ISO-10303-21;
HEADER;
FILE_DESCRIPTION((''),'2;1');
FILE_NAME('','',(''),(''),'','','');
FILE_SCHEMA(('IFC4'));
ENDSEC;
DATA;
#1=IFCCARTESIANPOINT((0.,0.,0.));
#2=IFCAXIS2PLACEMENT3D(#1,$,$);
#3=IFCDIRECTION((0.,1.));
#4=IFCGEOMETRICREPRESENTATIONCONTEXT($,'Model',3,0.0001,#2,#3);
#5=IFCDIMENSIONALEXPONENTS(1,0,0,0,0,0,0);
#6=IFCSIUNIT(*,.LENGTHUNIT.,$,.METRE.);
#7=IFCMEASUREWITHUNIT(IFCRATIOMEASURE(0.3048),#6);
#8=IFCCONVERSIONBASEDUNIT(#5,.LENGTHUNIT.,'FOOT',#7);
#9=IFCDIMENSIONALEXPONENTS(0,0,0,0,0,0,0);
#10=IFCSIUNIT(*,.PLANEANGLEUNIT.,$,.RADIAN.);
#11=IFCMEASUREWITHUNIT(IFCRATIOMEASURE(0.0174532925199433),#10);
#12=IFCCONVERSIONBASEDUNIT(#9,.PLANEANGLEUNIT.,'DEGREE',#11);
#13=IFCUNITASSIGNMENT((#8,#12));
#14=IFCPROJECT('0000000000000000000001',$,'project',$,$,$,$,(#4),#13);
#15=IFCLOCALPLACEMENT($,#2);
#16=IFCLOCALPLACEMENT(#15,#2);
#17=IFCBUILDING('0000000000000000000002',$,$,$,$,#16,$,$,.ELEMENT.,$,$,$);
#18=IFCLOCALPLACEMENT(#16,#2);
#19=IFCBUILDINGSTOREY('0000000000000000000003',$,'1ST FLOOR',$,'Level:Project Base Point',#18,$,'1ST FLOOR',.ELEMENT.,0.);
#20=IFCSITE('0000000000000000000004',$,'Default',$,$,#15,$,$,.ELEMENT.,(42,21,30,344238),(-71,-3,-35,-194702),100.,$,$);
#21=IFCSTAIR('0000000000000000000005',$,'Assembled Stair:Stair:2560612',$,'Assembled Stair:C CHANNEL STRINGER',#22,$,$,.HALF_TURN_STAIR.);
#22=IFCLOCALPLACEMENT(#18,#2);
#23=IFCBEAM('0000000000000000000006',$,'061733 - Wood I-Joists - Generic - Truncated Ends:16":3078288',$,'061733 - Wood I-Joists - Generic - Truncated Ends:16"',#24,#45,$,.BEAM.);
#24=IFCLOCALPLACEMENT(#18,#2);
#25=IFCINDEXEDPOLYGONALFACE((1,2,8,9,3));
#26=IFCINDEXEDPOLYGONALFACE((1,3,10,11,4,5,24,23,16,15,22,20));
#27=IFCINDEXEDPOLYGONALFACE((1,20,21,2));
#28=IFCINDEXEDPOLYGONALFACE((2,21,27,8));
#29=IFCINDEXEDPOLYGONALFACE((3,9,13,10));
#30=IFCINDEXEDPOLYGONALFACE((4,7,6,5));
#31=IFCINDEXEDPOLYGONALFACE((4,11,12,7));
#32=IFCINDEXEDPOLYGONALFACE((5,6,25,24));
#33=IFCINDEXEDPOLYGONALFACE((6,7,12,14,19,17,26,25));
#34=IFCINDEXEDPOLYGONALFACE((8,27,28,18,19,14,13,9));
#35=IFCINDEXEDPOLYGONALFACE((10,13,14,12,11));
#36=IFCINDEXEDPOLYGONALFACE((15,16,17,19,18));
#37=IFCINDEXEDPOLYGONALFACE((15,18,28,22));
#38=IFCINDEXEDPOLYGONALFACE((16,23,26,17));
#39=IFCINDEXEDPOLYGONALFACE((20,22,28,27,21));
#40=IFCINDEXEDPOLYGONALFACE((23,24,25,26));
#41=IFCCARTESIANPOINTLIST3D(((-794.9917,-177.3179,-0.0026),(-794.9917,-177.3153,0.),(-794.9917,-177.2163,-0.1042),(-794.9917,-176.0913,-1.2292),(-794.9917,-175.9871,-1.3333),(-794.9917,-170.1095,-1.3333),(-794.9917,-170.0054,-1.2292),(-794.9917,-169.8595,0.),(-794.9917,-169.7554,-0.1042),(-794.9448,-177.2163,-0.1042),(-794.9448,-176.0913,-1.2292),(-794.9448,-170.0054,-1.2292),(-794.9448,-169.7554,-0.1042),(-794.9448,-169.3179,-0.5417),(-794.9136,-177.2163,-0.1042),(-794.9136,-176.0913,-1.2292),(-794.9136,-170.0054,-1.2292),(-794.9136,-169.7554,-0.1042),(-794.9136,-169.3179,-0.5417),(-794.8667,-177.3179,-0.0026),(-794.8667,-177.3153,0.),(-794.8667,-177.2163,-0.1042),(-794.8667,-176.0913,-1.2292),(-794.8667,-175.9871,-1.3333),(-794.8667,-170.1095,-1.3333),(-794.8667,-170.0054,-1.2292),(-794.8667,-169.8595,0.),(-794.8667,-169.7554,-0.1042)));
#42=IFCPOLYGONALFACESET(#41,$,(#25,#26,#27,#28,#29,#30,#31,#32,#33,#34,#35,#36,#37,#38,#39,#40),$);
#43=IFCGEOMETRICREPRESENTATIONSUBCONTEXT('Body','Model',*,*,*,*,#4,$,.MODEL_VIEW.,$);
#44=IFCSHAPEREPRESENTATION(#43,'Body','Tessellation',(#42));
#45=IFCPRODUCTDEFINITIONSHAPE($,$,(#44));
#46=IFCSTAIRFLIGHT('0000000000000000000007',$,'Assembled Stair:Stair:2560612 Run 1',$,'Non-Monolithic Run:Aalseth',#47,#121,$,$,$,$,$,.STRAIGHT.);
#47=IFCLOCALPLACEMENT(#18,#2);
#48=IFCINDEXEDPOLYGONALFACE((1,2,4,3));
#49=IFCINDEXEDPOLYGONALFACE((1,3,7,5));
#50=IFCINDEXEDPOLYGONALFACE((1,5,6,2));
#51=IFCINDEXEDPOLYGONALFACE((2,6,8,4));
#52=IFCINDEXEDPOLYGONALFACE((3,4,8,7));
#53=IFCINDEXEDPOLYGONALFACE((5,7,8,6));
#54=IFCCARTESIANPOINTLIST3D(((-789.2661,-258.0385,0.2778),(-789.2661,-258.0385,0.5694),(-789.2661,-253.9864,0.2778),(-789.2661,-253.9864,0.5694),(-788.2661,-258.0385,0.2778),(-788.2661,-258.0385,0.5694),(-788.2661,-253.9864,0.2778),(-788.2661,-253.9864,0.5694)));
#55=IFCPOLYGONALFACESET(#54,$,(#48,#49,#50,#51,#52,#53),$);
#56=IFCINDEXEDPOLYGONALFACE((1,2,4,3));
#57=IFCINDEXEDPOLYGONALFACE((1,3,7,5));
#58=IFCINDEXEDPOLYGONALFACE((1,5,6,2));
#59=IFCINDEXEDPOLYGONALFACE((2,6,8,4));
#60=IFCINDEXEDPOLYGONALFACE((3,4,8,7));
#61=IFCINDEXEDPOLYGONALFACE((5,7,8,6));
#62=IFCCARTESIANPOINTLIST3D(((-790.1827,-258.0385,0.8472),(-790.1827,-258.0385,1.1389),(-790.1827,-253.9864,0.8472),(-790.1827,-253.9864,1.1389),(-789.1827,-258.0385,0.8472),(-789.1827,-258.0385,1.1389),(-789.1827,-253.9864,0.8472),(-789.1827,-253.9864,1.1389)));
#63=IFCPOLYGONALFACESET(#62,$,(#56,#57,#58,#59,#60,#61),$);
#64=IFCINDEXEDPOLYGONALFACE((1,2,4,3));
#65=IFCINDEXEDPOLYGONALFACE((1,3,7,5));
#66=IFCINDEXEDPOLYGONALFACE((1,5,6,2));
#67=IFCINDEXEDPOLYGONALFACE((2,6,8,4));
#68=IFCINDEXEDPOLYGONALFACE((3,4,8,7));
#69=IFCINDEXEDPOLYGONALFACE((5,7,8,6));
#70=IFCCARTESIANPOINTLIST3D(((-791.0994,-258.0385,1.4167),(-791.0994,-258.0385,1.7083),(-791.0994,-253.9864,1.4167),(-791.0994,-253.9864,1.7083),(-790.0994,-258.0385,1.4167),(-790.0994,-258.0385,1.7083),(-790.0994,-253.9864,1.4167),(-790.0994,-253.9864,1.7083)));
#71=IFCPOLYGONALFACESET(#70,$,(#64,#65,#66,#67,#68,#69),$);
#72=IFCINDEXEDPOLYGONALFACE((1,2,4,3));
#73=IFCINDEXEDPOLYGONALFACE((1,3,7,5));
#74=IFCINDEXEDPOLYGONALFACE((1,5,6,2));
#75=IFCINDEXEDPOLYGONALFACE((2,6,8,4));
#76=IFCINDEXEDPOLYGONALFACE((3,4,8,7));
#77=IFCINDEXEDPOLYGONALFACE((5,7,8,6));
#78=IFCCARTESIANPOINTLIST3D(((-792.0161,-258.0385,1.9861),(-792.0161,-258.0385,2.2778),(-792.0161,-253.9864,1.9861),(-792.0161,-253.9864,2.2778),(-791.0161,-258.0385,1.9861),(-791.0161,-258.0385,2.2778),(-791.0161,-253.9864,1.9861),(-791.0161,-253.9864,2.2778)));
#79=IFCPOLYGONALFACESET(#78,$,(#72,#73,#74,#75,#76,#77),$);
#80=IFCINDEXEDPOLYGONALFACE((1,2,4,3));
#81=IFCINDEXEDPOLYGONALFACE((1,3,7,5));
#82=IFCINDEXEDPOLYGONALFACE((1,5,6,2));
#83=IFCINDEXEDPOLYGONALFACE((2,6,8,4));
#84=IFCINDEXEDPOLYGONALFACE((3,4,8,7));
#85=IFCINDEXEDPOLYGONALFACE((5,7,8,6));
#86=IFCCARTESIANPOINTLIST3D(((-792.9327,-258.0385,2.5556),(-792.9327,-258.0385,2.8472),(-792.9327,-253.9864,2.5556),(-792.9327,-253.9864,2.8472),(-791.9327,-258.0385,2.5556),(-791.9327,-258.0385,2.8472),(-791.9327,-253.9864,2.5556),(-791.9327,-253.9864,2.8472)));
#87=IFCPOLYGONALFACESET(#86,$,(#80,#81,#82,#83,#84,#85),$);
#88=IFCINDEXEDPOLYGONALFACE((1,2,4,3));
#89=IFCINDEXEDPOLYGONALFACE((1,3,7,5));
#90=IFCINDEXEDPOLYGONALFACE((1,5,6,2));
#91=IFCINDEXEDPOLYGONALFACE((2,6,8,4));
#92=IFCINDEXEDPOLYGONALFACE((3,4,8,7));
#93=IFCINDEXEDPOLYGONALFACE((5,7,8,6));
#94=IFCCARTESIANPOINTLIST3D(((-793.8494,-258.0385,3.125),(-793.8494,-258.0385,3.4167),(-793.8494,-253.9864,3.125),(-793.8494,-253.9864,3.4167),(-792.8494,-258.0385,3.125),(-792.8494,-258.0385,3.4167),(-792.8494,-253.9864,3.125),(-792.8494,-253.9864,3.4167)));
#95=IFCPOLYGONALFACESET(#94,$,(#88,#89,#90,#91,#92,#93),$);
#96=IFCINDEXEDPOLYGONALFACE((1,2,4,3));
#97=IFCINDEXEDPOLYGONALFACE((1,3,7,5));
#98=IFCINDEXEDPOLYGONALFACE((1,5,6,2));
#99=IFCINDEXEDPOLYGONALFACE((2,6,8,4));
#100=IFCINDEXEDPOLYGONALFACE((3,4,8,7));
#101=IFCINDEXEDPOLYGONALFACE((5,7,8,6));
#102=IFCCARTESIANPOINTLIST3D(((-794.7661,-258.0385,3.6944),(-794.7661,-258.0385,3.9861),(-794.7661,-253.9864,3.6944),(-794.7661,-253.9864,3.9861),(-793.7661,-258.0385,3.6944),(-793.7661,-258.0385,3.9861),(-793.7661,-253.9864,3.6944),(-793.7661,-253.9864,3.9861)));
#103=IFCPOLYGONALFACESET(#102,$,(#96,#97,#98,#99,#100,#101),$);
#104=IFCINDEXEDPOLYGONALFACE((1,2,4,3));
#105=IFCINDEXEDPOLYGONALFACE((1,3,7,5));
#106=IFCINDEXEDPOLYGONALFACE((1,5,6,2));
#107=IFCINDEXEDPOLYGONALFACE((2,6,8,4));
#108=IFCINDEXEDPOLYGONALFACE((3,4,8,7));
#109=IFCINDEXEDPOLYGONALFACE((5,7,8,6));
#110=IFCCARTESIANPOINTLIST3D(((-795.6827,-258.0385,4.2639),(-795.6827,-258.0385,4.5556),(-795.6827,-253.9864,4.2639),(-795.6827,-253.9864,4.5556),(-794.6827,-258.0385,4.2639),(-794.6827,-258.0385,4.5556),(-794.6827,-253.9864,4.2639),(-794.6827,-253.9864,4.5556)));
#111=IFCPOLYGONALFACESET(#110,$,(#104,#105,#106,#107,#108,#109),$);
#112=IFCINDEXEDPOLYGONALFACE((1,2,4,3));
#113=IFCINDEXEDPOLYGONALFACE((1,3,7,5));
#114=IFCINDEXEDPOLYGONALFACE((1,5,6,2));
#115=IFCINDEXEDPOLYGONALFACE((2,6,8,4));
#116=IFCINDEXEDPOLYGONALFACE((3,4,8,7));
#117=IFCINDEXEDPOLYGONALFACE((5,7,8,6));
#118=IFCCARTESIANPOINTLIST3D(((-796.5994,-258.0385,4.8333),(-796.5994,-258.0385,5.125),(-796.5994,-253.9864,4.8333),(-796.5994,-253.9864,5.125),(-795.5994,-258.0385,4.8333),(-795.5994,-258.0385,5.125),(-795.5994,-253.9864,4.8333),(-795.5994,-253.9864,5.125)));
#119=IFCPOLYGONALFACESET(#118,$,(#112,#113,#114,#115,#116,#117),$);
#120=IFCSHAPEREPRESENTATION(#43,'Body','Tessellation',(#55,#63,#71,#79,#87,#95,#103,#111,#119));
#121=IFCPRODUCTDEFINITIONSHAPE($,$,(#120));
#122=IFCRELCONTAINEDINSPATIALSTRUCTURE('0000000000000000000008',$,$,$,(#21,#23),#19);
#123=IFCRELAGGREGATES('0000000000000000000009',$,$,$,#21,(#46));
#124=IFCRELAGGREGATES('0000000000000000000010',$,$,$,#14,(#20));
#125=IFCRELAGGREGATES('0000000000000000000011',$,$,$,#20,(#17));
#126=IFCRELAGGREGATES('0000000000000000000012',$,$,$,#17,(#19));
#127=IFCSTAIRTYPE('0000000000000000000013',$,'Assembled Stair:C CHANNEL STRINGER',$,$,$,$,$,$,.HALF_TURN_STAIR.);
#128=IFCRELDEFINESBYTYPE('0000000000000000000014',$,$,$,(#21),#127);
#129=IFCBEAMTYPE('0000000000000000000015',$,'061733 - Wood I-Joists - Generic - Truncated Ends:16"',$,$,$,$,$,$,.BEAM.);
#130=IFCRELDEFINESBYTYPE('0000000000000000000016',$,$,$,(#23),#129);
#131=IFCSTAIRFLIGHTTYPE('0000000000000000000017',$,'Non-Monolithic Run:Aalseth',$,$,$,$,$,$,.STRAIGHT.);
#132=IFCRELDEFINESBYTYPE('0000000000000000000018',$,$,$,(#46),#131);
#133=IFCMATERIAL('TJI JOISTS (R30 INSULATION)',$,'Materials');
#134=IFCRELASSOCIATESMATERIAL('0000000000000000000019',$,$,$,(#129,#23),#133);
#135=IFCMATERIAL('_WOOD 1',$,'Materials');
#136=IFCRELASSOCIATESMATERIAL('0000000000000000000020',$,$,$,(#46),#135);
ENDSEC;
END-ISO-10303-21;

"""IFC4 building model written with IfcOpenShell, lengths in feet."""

from ifc_helpers import new_model, entity, si_unit, converted_unit, direction, frame, frame_2d, origin, place, context, subcontext, project, spatial, polyline, rectangle, outline, extrude, clip, bounded_halfspace, source, transform, mapped, material, material_profile, profile_set, profile_usage, type_object, type_shapes, element, aggregate, save


model = new_model("IFC4")

# Units and contexts
model_context = context("Model", 3, precision=0.0001, world=origin(), true_north=direction((0.0, 1.0)))
body_context = subcontext(model_context, "Body", "Model", "MODEL_VIEW")
ifc_project = project(units=[converted_unit("LENGTHUNIT", "FOOT", entity("IfcRatioMeasure", 0.3048), si_unit("LENGTHUNIT", "METRE"), dimensions=[1, 0, 0, 0, 0, 0, 0]), converted_unit("PLANEANGLEUNIT", "DEGREE", entity("IfcRatioMeasure", 0.0174532925199433), si_unit("PLANEANGLEUNIT", "RADIAN"), dimensions=[0, 0, 0, 0, 0, 0, 0])], contexts=[model_context])

# Site, building, storey
site_placement = place(None, origin())
site = spatial("IfcSite", under=ifc_project, at=site_placement, Name="Default", CompositionType="ELEMENT", RefLatitude=(42, 21, 30, 344238), RefLongitude=(-71, -3, -35, -194702), RefElevation=100.0)
building_placement = place(site_placement, origin())
building = spatial("IfcBuilding", under=site, at=building_placement, CompositionType="ELEMENT")
storey_placement = place(building_placement, origin())
storey = spatial("IfcBuildingStorey", under=building, at=storey_placement, Name="1ST FLOOR", ObjectType="Level:Project Base Point", LongName="1ST FLOOR", CompositionType="ELEMENT", Elevation=0.0)

# Stair
stair_type_1 = type_object("IfcStairType", Name="Assembled Stair:C CHANNEL STRINGER", PredefinedType="HALF_TURN_STAIR")
stair_1_placement = place(storey_placement, origin())
stair_1 = element("IfcStair", 1, at=stair_1_placement, inside=storey, type_object=stair_type_1, Name="Assembled Stair:Stair:2560612", ObjectType="Assembled Stair:C CHANNEL STRINGER", PredefinedType="HALF_TURN_STAIR")

# Beam
ifc_material_1 = material(Name="TJI JOISTS (R30 INSULATION)", Category="Materials")
ifc_material_profile_1 = material_profile(ifc_material_1, outline(polyline([(-0.0625, -0.5625), (-0.0625, -0.6667), (0.0625, -0.6667), (0.0625, -0.5625), (0.0156, -0.5625), (0.0156, 0.5625), (0.0625, 0.5625), (0.0625, 0.6667), (-0.0625, 0.6667), (-0.0625, 0.5625), (-0.0156, 0.5625), (-0.0156, -0.5625), (-0.0625, -0.5625)])), Name="16\"")
ifc_profile_set_1 = profile_set([ifc_material_profile_1], Name="16\"")
ifc_profile_usage_1 = profile_usage(ifc_profile_set_1, cardinal=8)
beam_type_1 = type_object("IfcBeamType", Name="061733 - Wood I-Joists - Generic - Truncated Ends:16\"", PredefinedType="BEAM", material=ifc_profile_set_1)
shared_shape_1 = source(origin(), body_context, "Body", "Clipping", [
    clip(clip(clip(clip(extrude(outline(polyline([(-0.0625, -0.5625), (-0.0625, -0.6667), (0.0625, -0.6667), (0.0625, -0.5625), (0.0156, -0.5625), (0.0156, 0.5625), (0.0625, 0.5625), (0.0625, 0.6667), (-0.0625, 0.6667), (-0.0625, 0.5625), (-0.0156, 0.5625), (-0.0156, -0.5625), (-0.0625, -0.5625)])), frame((-4.0, -0.0057, 0.0), z_axis=(-1.0, 0.0, 0.0), x_axis=(0.0, 1.0, 0.0)), (0.0, 0.0, -1.0), 8.0), bounded_halfspace(frame((-3.2083, -0.0682, -0.6667), z_axis=(-0.707107, 0.0, -0.707107), x_axis=(0.0, 1.0, 0.0)), False, frame((-4.0, -0.0057, 0.0), z_axis=(-1.0, 0.0, 0.0), x_axis=(0.0, 1.0, 0.0)), polyline([(-0.0156, -0.125), (0.0156, -0.125), (0.0156, 0.5625), (0.0625, 0.5625), (0.0625, 0.6667), (-0.0625, 0.6667), (-0.0625, 0.5625), (-0.0156, 0.5625), (-0.0156, -0.125)]))), bounded_halfspace(frame((-4.0, -0.0682, 0.125), z_axis=(-0.707107, 0.0, 0.707107), x_axis=(0.0, 1.0, 0.0)), False, frame((-4.0, -0.0057, 0.0), z_axis=(-1.0, 0.0, 0.0), x_axis=(0.0, 1.0, 0.0)), polyline([(0.0156, -0.125), (-0.0156, -0.125), (-0.0156, -0.5625), (-0.0625, -0.5625), (-0.0625, -0.6667), (0.0625, -0.6667), (0.0625, -0.5625), (0.0156, -0.5625), (0.0156, -0.125)]))), bounded_halfspace(frame((4.0, -0.0682, 0.6641), z_axis=(0.707107, 0.0, -0.707107), x_axis=(0.0, 1.0, 0.0)), False, frame((-4.0, -0.0057, 0.0), z_axis=(-1.0, 0.0, 0.0), x_axis=(0.0, 1.0, 0.0)), polyline([(0.0625, -0.6641), (-0.0625, -0.6641), (-0.0625, -0.5625), (-0.0156, -0.5625), (-0.0156, 0.5625), (-0.0625, 0.5625), (-0.0625, 0.6667), (0.0625, 0.6667), (0.0625, 0.5625), (0.0156, 0.5625), (0.0156, -0.5625), (0.0625, -0.5625), (0.0625, -0.6641)]))), bounded_halfspace(frame((3.9974, -0.0682, 0.6667), z_axis=(0.707107, 0.0, 0.707107), x_axis=(0.0, 1.0, 0.0)), False, frame((-4.0, -0.0057, 0.0), z_axis=(-1.0, 0.0, 0.0), x_axis=(0.0, 1.0, 0.0)), polyline([(-0.0625, -0.6641), (0.0625, -0.6641), (0.0625, -0.6667), (-0.0625, -0.6667), (-0.0625, -0.6641)]))),
])
type_shapes(beam_type_1, [shared_shape_1])
beam_1_placement = place(storey_placement, frame((-794.9235, -173.3179, -0.6667), z_axis=(0.0, 0.0, 1.0), x_axis=(0.0, -1.0, 0.0)))
element("IfcBeam", 2, at=beam_1_placement, inside=storey, type_object=beam_type_1, material=ifc_profile_usage_1, Name="061733 - Wood I-Joists - Generic - Truncated Ends:16\":3078288", ObjectType="061733 - Wood I-Joists - Generic - Truncated Ends:16\"", PredefinedType="BEAM", context=body_context, shape_type="MappedRepresentation", body=[
    mapped(shared_shape_1, transform((0.0, 0.0, 0.0), scale=1.0)),
])

# Shared definitions
ifc_material_2 = material(Name="_WOOD 1", Category="Materials")

# Stair flight
stair_flight_type_1 = type_object("IfcStairFlightType", Name="Non-Monolithic Run:Aalseth", PredefinedType="STRAIGHT")
stair_flight_1_placement = place(stair_1_placement, frame((-796.5994, -258.0385, 0.0)))
stair_flight_1 = element("IfcStairFlight", 3, at=stair_flight_1_placement, type_object=stair_flight_type_1, material=ifc_material_2, Name="Assembled Stair:Stair:2560612 Run 1", ObjectType="Non-Monolithic Run:Aalseth", PredefinedType="STRAIGHT", context=body_context, shape_type="SweptSolid", body=[
    extrude(rectangle(XDim=1.0, YDim=4.0521, at=frame_2d((0.0, 0.0), x_axis=(1.0, 0.0))), frame((7.8333, 2.026, 0.2778)), (0.0, 0.0, 1.0), 0.2917),
    extrude(rectangle(XDim=1.0, YDim=4.0521, at=frame_2d((0.0, 0.0), x_axis=(1.0, 0.0))), frame((6.9167, 2.026, 0.8472)), (0.0, 0.0, 1.0), 0.2917),
    extrude(rectangle(XDim=1.0, YDim=4.0521, at=frame_2d((0.0, 0.0), x_axis=(1.0, 0.0))), frame((6.0, 2.026, 1.4167)), (0.0, 0.0, 1.0), 0.2917),
    extrude(rectangle(XDim=1.0, YDim=4.0521, at=frame_2d((0.0, 0.0), x_axis=(1.0, 0.0))), frame((5.0833, 2.026, 1.9861)), (0.0, 0.0, 1.0), 0.2917),
    extrude(rectangle(XDim=1.0, YDim=4.0521, at=frame_2d((0.0, 0.0), x_axis=(1.0, 0.0))), frame((4.1667, 2.026, 2.5556)), (0.0, 0.0, 1.0), 0.2917),
    extrude(rectangle(XDim=1.0, YDim=4.0521, at=frame_2d((0.0, 0.0), x_axis=(1.0, 0.0))), frame((3.25, 2.026, 3.125)), (0.0, 0.0, 1.0), 0.2917),
    extrude(rectangle(XDim=1.0, YDim=4.0521, at=frame_2d((0.0, 0.0), x_axis=(1.0, 0.0))), frame((2.3333, 2.026, 3.6944)), (0.0, 0.0, 1.0), 0.2917),
    extrude(rectangle(XDim=1.0, YDim=4.0521, at=frame_2d((0.0, 0.0), x_axis=(1.0, 0.0))), frame((1.4167, 2.026, 4.2639)), (0.0, 0.0, 1.0), 0.2917),
    extrude(rectangle(XDim=1.0, YDim=4.0521, at=frame_2d((0.0, 0.0), x_axis=(1.0, 0.0))), frame((0.5, 2.026, 4.8333)), (0.0, 0.0, 1.0), 0.2917),
])
aggregate(stair_1, [stair_flight_1])

save(model, "model.ifc")
